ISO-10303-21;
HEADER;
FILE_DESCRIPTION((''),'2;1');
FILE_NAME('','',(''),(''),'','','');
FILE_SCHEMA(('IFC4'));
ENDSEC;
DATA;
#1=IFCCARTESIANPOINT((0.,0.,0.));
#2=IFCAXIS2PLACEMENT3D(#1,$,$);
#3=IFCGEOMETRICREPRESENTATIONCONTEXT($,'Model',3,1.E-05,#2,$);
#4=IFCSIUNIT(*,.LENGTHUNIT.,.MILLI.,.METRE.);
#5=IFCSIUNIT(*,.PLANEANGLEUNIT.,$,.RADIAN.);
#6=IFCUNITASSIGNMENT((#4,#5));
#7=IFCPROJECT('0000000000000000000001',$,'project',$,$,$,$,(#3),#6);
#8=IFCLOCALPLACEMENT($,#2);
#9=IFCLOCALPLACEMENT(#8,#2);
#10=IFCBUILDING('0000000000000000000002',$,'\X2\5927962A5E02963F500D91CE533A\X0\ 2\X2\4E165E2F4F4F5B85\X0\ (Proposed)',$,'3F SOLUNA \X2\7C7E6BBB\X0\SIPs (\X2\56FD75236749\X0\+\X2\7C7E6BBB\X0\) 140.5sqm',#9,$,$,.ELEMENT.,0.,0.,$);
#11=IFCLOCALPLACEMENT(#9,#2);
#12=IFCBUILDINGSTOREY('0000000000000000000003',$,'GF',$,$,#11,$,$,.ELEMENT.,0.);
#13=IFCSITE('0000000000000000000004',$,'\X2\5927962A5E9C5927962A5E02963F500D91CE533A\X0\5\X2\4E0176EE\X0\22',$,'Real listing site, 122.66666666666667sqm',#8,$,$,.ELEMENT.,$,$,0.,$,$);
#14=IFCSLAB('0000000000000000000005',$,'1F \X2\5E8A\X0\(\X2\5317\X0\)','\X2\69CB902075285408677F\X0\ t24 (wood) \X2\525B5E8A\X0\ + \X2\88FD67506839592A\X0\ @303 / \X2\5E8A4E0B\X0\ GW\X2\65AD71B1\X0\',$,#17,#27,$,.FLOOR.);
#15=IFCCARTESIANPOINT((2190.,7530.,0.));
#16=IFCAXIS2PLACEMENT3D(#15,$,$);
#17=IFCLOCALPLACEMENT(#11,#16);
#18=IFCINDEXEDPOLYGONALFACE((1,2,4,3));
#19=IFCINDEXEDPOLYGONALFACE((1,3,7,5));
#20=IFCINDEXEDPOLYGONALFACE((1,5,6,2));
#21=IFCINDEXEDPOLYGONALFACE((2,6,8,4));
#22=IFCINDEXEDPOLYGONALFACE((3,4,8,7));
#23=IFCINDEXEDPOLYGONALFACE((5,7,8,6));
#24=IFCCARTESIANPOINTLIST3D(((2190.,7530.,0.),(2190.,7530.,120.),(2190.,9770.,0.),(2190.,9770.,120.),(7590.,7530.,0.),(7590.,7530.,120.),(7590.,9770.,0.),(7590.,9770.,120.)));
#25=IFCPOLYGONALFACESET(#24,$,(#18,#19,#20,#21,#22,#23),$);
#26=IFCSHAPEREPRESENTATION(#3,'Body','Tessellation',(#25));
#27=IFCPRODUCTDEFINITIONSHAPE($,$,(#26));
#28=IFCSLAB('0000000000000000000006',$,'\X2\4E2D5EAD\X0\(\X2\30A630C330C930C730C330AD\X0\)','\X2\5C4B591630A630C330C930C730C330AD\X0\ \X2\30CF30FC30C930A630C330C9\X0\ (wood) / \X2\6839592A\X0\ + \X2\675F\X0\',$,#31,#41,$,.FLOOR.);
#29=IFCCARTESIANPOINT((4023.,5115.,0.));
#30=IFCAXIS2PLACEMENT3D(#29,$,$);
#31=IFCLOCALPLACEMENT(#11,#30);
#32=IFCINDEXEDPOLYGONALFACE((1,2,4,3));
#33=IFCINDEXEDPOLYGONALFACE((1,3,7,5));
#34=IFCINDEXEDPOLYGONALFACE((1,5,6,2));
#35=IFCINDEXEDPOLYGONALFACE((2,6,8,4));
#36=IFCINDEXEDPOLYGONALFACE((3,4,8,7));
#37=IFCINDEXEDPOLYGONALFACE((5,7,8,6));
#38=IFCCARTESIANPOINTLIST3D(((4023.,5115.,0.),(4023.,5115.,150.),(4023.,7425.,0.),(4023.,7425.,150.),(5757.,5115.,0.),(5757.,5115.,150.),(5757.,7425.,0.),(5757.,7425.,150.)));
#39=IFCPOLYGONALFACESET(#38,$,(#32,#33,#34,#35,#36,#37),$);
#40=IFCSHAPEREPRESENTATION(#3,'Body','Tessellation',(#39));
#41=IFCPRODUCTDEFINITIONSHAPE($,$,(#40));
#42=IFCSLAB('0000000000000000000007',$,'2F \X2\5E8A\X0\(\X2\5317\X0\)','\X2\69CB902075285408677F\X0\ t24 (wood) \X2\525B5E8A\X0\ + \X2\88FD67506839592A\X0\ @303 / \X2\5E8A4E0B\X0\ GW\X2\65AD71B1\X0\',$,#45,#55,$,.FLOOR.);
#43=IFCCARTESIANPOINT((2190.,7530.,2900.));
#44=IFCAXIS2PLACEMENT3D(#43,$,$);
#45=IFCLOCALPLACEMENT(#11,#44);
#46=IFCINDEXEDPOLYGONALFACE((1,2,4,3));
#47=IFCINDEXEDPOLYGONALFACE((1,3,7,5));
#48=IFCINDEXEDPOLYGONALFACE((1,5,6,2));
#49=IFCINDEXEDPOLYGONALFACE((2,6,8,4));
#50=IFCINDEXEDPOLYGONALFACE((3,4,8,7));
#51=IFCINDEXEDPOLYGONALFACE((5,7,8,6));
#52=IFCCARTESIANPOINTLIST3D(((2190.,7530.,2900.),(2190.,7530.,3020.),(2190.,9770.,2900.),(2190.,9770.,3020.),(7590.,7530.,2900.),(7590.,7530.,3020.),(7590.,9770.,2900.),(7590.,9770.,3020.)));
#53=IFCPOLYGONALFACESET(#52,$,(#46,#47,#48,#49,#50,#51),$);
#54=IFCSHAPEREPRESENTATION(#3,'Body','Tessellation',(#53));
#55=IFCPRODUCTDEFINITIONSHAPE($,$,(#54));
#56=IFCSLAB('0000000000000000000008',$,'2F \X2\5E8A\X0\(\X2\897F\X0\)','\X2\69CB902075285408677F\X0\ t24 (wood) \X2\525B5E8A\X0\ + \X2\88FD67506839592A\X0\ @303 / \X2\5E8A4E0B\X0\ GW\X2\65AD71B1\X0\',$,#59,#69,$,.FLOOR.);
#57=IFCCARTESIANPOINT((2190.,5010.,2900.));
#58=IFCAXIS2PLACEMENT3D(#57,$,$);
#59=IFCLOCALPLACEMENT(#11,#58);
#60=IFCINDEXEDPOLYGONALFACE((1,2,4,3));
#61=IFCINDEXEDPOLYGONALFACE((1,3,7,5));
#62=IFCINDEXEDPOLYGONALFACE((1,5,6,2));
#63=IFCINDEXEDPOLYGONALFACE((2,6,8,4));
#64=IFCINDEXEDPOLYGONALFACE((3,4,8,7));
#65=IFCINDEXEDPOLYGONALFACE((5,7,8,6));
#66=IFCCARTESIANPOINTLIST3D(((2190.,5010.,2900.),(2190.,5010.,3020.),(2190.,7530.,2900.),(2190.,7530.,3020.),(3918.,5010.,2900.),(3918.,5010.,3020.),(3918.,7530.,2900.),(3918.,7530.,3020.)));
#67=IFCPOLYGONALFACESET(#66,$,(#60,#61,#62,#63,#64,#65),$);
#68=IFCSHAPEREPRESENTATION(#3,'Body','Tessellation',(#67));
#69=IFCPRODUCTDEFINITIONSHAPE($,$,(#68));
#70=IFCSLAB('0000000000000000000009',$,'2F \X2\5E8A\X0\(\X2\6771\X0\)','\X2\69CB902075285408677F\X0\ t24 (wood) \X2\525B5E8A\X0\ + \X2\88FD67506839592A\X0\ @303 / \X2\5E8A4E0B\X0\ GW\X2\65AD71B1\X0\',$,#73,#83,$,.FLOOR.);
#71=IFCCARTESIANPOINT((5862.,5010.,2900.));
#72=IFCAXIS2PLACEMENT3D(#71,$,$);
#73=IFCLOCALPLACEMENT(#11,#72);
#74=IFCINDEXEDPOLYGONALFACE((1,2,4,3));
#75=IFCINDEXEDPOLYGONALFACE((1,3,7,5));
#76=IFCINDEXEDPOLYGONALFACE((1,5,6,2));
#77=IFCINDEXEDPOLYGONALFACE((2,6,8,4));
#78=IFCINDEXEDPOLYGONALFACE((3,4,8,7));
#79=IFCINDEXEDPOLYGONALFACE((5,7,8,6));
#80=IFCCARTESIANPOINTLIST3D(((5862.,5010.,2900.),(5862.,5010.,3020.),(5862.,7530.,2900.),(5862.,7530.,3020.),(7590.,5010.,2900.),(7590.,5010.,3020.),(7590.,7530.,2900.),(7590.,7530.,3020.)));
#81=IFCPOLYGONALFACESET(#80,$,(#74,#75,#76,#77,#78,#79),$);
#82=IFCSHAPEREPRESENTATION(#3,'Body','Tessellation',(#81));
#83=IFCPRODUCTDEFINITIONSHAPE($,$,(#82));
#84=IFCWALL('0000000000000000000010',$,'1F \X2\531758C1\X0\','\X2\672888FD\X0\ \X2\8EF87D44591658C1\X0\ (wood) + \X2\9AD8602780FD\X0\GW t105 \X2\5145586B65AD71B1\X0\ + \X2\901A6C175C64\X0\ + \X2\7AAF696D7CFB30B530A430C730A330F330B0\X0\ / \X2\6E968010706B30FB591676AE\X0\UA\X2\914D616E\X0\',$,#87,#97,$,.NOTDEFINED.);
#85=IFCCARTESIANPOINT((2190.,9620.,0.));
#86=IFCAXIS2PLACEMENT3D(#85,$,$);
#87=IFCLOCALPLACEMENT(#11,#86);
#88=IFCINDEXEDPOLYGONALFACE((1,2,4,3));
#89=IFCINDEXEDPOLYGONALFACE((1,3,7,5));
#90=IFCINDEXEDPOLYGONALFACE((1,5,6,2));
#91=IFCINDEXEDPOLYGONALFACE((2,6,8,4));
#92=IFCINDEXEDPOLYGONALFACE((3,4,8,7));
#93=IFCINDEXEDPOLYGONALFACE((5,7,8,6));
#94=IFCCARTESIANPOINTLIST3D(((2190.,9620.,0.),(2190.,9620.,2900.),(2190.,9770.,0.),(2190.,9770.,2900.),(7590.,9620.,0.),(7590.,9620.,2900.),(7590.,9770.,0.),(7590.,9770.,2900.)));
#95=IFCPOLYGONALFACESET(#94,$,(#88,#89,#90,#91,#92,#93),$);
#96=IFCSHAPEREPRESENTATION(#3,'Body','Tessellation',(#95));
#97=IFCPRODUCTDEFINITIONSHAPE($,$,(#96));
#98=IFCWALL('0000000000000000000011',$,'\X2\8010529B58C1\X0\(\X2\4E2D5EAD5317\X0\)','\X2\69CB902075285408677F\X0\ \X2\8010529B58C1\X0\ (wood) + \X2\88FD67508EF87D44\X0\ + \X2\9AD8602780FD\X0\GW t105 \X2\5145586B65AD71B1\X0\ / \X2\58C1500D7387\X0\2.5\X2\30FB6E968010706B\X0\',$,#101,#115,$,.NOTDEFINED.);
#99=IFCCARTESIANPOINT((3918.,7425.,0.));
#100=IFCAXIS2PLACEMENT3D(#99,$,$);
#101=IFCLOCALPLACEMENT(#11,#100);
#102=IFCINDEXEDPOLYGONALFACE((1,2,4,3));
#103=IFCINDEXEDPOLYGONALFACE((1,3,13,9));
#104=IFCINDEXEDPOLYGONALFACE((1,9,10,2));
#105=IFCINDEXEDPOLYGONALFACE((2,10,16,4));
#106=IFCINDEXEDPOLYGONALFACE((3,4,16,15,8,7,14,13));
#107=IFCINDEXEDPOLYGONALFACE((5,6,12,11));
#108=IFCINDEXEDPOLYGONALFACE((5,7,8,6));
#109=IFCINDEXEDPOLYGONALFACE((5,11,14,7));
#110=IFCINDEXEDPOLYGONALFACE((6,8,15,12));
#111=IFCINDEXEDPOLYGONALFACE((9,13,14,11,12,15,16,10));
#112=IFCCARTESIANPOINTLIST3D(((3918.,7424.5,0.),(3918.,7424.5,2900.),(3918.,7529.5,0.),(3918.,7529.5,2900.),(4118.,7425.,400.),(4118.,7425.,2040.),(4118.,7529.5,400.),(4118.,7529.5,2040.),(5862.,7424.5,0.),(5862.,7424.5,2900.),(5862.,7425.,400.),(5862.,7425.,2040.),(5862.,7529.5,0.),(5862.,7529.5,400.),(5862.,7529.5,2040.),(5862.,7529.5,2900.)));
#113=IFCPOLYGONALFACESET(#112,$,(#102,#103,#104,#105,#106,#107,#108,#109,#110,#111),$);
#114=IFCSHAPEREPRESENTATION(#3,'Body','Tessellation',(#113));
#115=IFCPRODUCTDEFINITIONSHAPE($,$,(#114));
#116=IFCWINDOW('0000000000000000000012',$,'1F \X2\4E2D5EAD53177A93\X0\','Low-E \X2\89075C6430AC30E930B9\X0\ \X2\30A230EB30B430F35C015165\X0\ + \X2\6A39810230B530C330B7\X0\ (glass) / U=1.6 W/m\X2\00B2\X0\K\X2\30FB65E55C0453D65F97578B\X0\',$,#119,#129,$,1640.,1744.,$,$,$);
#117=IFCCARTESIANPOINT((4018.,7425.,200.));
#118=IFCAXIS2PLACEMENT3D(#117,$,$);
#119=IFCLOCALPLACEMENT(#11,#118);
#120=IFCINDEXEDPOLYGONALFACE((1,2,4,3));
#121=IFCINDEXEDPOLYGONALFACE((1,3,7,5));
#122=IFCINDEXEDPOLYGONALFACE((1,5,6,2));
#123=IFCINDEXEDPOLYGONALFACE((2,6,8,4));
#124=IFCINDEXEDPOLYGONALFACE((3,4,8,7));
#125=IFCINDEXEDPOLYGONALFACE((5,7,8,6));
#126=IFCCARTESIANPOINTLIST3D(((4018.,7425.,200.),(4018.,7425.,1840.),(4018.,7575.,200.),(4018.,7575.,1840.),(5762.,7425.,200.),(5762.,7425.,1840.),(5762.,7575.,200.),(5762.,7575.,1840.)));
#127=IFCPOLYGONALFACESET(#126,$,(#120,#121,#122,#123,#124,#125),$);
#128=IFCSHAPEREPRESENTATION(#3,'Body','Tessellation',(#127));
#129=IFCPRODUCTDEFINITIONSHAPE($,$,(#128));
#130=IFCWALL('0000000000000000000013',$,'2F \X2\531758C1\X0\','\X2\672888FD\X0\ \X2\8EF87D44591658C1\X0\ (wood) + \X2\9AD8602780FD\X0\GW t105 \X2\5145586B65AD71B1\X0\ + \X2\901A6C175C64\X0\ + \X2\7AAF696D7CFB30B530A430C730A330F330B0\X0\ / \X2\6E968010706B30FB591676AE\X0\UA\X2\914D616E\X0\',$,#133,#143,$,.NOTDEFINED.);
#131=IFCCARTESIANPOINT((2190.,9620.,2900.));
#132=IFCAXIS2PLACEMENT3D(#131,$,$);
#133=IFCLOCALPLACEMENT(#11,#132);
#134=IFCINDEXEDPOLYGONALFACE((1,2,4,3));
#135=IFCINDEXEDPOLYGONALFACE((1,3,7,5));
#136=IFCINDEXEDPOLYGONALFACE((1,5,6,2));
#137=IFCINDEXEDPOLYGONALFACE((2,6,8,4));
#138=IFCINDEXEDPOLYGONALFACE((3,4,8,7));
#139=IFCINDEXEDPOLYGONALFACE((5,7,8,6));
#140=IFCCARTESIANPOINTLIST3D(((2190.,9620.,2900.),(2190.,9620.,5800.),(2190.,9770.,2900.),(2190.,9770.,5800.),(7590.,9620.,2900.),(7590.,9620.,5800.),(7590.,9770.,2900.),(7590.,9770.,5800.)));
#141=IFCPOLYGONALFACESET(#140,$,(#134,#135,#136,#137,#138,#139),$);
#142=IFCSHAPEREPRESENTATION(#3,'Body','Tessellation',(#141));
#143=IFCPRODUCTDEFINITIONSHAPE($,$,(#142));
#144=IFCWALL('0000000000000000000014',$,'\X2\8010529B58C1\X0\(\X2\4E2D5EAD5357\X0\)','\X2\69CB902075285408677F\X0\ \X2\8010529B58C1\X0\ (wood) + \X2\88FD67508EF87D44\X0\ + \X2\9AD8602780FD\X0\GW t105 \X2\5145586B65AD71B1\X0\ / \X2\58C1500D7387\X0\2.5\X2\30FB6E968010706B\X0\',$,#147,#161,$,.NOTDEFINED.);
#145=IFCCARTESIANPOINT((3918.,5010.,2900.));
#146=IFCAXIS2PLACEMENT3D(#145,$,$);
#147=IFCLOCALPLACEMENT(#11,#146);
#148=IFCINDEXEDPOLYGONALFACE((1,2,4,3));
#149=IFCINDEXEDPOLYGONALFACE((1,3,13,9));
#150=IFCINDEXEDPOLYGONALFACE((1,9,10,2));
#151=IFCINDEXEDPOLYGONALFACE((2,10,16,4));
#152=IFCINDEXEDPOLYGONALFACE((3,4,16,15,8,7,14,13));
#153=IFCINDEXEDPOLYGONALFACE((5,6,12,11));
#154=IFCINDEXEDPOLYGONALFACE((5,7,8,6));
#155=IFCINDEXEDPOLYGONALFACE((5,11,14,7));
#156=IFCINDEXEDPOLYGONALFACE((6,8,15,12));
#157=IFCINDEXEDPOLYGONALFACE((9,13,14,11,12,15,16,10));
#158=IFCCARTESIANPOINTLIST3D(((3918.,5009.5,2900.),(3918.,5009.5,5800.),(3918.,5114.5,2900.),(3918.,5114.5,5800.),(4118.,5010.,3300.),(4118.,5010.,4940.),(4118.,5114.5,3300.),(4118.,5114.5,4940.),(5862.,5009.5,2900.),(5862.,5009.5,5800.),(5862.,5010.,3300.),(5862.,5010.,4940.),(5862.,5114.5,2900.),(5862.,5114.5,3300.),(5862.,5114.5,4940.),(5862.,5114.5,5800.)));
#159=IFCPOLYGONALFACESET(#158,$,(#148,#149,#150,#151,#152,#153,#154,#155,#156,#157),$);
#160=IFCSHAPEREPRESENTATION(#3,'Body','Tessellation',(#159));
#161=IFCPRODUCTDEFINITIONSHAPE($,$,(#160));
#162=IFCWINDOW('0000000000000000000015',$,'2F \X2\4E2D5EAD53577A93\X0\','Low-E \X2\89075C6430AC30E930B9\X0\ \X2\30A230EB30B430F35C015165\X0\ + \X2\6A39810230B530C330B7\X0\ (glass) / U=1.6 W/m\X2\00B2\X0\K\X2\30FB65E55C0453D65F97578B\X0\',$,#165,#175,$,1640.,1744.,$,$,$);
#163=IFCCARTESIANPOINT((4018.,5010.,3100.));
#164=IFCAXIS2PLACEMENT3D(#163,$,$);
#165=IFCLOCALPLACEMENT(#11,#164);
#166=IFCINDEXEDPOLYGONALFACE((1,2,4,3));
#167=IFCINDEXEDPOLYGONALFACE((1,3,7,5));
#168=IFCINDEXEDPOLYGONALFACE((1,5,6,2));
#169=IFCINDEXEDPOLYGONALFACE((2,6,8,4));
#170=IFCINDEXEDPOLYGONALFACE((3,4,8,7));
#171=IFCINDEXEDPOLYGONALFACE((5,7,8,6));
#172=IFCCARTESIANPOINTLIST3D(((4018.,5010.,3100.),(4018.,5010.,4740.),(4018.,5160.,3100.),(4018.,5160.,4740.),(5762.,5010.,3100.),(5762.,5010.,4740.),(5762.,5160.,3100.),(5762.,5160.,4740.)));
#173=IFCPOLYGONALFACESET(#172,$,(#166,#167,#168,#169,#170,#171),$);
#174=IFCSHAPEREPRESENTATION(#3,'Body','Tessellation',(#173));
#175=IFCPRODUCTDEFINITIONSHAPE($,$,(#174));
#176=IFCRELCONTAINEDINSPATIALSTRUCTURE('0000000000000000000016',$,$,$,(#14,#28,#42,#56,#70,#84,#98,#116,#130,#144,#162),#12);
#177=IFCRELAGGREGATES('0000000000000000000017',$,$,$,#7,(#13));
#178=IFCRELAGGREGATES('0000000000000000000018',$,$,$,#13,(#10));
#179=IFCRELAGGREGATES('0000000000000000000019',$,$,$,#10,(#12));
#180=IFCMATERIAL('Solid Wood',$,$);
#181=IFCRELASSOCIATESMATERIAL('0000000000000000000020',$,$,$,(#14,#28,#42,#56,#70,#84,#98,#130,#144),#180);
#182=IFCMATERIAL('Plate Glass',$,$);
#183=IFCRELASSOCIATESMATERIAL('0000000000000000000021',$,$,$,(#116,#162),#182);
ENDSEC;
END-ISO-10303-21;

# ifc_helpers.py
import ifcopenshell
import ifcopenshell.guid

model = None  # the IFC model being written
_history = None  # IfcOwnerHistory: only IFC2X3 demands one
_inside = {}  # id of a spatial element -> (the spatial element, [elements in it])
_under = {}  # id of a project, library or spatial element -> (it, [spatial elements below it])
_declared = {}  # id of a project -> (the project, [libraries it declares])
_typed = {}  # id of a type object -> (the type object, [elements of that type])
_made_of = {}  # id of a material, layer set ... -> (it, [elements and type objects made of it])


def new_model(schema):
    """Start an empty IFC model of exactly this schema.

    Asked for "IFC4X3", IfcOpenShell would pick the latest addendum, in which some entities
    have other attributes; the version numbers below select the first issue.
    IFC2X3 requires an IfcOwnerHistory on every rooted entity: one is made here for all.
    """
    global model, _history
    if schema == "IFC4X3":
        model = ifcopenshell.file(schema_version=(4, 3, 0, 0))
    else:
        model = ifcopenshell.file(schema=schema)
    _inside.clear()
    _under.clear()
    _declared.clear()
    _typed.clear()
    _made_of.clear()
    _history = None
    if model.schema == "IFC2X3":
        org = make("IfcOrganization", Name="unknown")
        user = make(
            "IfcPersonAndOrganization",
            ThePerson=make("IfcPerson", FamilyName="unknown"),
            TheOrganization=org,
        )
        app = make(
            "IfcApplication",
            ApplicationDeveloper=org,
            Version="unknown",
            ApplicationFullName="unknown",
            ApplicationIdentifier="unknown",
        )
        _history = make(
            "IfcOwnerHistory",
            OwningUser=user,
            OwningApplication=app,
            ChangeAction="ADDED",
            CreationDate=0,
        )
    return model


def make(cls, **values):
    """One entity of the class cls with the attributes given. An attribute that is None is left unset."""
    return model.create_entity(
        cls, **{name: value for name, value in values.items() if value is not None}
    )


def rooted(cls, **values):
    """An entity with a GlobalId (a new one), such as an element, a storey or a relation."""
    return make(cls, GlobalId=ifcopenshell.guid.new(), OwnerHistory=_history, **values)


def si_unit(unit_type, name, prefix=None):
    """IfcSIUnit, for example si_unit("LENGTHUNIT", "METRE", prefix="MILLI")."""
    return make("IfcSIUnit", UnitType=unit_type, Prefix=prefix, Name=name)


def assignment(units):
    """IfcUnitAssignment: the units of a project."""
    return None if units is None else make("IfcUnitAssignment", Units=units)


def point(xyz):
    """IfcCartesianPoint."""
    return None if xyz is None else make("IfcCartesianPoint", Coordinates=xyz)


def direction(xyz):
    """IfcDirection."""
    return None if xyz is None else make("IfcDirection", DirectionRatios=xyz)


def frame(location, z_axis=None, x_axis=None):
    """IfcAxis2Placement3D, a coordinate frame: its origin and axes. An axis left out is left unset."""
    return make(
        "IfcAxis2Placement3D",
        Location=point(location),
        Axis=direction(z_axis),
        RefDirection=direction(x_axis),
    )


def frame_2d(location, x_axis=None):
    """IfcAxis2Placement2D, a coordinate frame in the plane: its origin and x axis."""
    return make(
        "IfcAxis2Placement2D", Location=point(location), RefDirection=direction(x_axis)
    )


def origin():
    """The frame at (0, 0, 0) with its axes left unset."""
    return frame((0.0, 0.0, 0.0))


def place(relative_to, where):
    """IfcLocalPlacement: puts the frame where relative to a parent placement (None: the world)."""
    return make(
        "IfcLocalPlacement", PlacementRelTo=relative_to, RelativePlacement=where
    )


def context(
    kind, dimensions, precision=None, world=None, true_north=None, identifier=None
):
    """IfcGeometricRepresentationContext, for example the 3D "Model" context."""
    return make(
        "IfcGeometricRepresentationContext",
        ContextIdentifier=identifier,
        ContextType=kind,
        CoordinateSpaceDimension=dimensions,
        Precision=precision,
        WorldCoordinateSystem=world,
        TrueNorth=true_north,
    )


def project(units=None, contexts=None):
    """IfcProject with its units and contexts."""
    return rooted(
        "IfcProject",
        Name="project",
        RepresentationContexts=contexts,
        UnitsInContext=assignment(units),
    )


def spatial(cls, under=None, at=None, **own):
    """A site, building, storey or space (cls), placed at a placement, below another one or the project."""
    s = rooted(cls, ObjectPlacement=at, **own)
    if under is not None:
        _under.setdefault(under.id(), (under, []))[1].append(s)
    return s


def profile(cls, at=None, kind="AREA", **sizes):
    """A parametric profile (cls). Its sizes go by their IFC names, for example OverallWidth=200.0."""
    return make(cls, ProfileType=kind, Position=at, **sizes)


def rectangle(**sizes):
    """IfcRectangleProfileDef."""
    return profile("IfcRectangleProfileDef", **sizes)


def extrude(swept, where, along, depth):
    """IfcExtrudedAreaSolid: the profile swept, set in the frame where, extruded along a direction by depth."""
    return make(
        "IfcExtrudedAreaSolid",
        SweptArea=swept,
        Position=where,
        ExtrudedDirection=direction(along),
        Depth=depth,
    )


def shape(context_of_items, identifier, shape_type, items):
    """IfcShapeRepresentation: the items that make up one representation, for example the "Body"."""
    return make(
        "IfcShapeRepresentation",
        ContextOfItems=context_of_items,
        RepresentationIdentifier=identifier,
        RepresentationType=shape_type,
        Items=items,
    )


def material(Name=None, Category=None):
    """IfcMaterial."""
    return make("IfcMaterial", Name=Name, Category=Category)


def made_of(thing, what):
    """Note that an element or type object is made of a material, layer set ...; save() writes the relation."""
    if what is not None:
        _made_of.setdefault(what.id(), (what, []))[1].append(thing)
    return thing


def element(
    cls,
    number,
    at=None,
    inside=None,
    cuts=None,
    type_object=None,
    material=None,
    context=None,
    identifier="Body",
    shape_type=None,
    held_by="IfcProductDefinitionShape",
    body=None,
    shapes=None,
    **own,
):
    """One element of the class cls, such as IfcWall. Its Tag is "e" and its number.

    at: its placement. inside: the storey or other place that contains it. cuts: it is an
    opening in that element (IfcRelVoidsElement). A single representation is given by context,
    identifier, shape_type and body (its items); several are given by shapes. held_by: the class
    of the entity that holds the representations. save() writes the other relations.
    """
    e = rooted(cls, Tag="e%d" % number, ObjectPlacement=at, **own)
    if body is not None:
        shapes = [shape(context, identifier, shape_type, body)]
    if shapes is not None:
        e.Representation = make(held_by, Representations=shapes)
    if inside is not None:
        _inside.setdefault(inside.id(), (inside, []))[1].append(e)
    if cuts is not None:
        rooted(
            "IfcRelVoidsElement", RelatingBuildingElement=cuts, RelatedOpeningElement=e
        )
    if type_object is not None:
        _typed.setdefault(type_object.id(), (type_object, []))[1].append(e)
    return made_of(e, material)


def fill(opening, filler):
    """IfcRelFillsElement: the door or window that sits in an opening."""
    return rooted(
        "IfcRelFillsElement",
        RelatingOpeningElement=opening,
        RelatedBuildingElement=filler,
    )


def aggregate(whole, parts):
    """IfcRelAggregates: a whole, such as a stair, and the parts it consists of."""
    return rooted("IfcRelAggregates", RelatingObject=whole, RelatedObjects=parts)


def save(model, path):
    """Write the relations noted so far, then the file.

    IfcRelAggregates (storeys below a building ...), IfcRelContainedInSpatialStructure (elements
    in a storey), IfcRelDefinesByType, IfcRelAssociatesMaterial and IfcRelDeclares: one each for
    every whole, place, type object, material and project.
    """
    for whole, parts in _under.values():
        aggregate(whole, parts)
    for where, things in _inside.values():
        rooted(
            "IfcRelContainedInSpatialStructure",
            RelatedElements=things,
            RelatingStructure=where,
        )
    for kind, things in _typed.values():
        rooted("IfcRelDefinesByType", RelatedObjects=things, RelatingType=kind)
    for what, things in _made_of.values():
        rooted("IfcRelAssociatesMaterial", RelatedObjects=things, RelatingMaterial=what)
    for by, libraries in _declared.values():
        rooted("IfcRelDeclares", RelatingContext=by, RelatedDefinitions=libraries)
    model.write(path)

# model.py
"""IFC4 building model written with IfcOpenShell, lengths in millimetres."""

from ifc_helpers import new_model, si_unit, frame, frame_2d, origin, place, context, project, spatial, rectangle, extrude, material, element, fill, save


model = new_model("IFC4")

# Units and contexts
model_context = context("Model", 3, precision=1e-05, world=origin())
ifc_project = project(units=[si_unit("LENGTHUNIT", "METRE", prefix="MILLI"), si_unit("PLANEANGLEUNIT", "RADIAN")], contexts=[model_context])

# Site, building, storey
site_placement = place(None, origin())
site = spatial("IfcSite", under=ifc_project, at=site_placement, Name="大阪府大阪市阿倍野区5丁目22", ObjectType="Real listing site, 122.66666666666667sqm", CompositionType="ELEMENT", RefElevation=0.0)
building_placement = place(site_placement, origin())
building = spatial("IfcBuilding", under=site, at=building_placement, Name="大阪市阿倍野区 2世帯住宅 (Proposed)", ObjectType="3F SOLUNA 籾殻SIPs (国産杉+籾殻) 140.5sqm", CompositionType="ELEMENT", ElevationOfRefHeight=0.0, ElevationOfTerrain=0.0)
storey_placement = place(building_placement, origin())
storey = spatial("IfcBuildingStorey", under=building, at=storey_placement, Name="GF", CompositionType="ELEMENT", Elevation=0.0)

# Slabs
ifc_material_1 = material(Name="Solid Wood")
slab_1_placement = place(storey_placement, frame((2190.0, 7530.0, 0.0)))
element("IfcSlab", 1, at=slab_1_placement, inside=storey, material=ifc_material_1, Name="1F 床(北)", Description="構造用合板 t24 (wood) 剛床 + 製材根太 @303 / 床下 GW断熱", PredefinedType="FLOOR", context=model_context, shape_type="SweptSolid", body=[
    extrude(rectangle(XDim=5400.0, YDim=2240.0, at=frame_2d((2700.0, 1120.0))), frame((2190.0, 7530.0, 0.0)), (0.0, 0.0, 1.0), 120.0),
])
slab_2_placement = place(storey_placement, frame((4023.0, 5115.0, 0.0)))
element("IfcSlab", 2, at=slab_2_placement, inside=storey, material=ifc_material_1, Name="中庭(ウッドデッキ)", Description="屋外ウッドデッキ ハードウッド (wood) / 根太 + 束", PredefinedType="FLOOR", context=model_context, shape_type="SweptSolid", body=[
    extrude(rectangle(XDim=1734.0, YDim=2310.0, at=frame_2d((867.0, 1155.0))), frame((4023.0, 5115.0, 0.0)), (0.0, 0.0, 1.0), 150.0),
])
slab_3_placement = place(storey_placement, frame((2190.0, 7530.0, 2900.0)))
element("IfcSlab", 3, at=slab_3_placement, inside=storey, material=ifc_material_1, Name="2F 床(北)", Description="構造用合板 t24 (wood) 剛床 + 製材根太 @303 / 床下 GW断熱", PredefinedType="FLOOR", context=model_context, shape_type="SweptSolid", body=[
    extrude(rectangle(XDim=5400.0, YDim=2240.0, at=frame_2d((2700.0, 1120.0))), frame((2190.0, 7530.0, 2900.0)), (0.0, 0.0, 1.0), 120.0),
])
slab_4_placement = place(storey_placement, frame((2190.0, 5010.0, 2900.0)))
element("IfcSlab", 4, at=slab_4_placement, inside=storey, material=ifc_material_1, Name="2F 床(西)", Description="構造用合板 t24 (wood) 剛床 + 製材根太 @303 / 床下 GW断熱", PredefinedType="FLOOR", context=model_context, shape_type="SweptSolid", body=[
    extrude(rectangle(XDim=1728.0, YDim=2520.0, at=frame_2d((864.0, 1260.0))), frame((2190.0, 5010.0, 2900.0)), (0.0, 0.0, 1.0), 120.0),
])
slab_5_placement = place(storey_placement, frame((5862.0, 5010.0, 2900.0)))
element("IfcSlab", 5, at=slab_5_placement, inside=storey, material=ifc_material_1, Name="2F 床(東)", Description="構造用合板 t24 (wood) 剛床 + 製材根太 @303 / 床下 GW断熱", PredefinedType="FLOOR", context=model_context, shape_type="SweptSolid", body=[
    extrude(rectangle(XDim=1728.0, YDim=2520.0, at=frame_2d((864.0, 1260.0))), frame((5862.0, 5010.0, 2900.0)), (0.0, 0.0, 1.0), 120.0),
])

# Wall
wall_1_placement = place(storey_placement, frame((2190.0, 9620.0, 0.0)))
element("IfcWall", 6, at=wall_1_placement, inside=storey, material=ifc_material_1, Name="1F 北壁", Description="木製 軸組外壁 (wood) + 高性能GW t105 充填断熱 + 通気層 + 窯業系サイディング / 準耐火・外皮UA配慮", PredefinedType="NOTDEFINED", context=model_context, shape_type="SweptSolid", body=[
    extrude(rectangle(XDim=5400.0, YDim=150.0, at=frame_2d((2700.0, 75.0))), frame((2190.0, 9620.0, 0.0)), (0.0, 0.0, 1.0), 2900.0),
])

# Wall, opening, window
wall_2_placement = place(storey_placement, frame((3918.0, 7425.0, 0.0)))
wall_2 = element("IfcWall", 7, at=wall_2_placement, inside=storey, material=ifc_material_1, Name="耐力壁(中庭北)", Description="構造用合板 耐力壁 (wood) + 製材軸組 + 高性能GW t105 充填断熱 / 壁倍率2.5・準耐火", PredefinedType="NOTDEFINED", context=model_context, shape_type="SweptSolid", body=[
    extrude(rectangle(XDim=1944.0, YDim=105.0, at=frame_2d((972.0, 52.0))), frame((3918.0, 7425.0, 0.0)), (0.0, 0.0, 1.0), 2900.0),
])
opening_1_placement = place(storey_placement, frame((4018.0, 7425.0, 200.0)))
opening_1 = element("IfcOpeningElement", 8, at=opening_1_placement, cuts=wall_2, PredefinedType="NOTDEFINED", context=model_context, shape_type="SweptSolid", body=[
    extrude(rectangle(XDim=1744.0, YDim=150.0, at=frame_2d((872.0, 75.0))), frame((4018.0, 7425.0, 200.0)), (0.0, 0.0, 1.0), 1640.0),
])
ifc_material_2 = material(Name="Plate Glass")
window_1_placement = place(storey_placement, frame((4018.0, 7425.0, 200.0)))
window_1 = element("IfcWindow", 9, at=window_1_placement, inside=storey, material=ifc_material_2, Name="1F 中庭北窓", Description="Low-E 複層ガラス アルゴン封入 + 樹脂サッシ (glass) / U=1.6 W/m²K・日射取得型", OverallHeight=1640.0, OverallWidth=1744.0, context=model_context, shape_type="SweptSolid", body=[
    extrude(rectangle(XDim=1744.0, YDim=150.0, at=frame_2d((872.0, 75.0))), frame((4018.0, 7425.0, 200.0)), (0.0, 0.0, 1.0), 1640.0),
])
fill(opening_1, window_1)

# Wall
wall_3_placement = place(storey_placement, frame((2190.0, 9620.0, 2900.0)))
element("IfcWall", 10, at=wall_3_placement, inside=storey, material=ifc_material_1, Name="2F 北壁", Description="木製 軸組外壁 (wood) + 高性能GW t105 充填断熱 + 通気層 + 窯業系サイディング / 準耐火・外皮UA配慮", PredefinedType="NOTDEFINED", context=model_context, shape_type="SweptSolid", body=[
    extrude(rectangle(XDim=5400.0, YDim=150.0, at=frame_2d((2700.0, 75.0))), frame((2190.0, 9620.0, 2900.0)), (0.0, 0.0, 1.0), 2900.0),
])

# Wall, opening, window
wall_4_placement = place(storey_placement, frame((3918.0, 5010.0, 2900.0)))
wall_4 = element("IfcWall", 11, at=wall_4_placement, inside=storey, material=ifc_material_1, Name="耐力壁(中庭南)", Description="構造用合板 耐力壁 (wood) + 製材軸組 + 高性能GW t105 充填断熱 / 壁倍率2.5・準耐火", PredefinedType="NOTDEFINED", context=model_context, shape_type="SweptSolid", body=[
    extrude(rectangle(XDim=1944.0, YDim=105.0, at=frame_2d((972.0, 52.0))), frame((3918.0, 5010.0, 2900.0)), (0.0, 0.0, 1.0), 2900.0),
])
opening_2_placement = place(storey_placement, frame((4018.0, 5010.0, 3100.0)))
opening_2 = element("IfcOpeningElement", 12, at=opening_2_placement, cuts=wall_4, PredefinedType="NOTDEFINED", context=model_context, shape_type="SweptSolid", body=[
    extrude(rectangle(XDim=1744.0, YDim=150.0, at=frame_2d((872.0, 75.0))), frame((4018.0, 5010.0, 3100.0)), (0.0, 0.0, 1.0), 1640.0),
])
window_2_placement = place(storey_placement, frame((4018.0, 5010.0, 3100.0)))
window_2 = element("IfcWindow", 13, at=window_2_placement, inside=storey, material=ifc_material_2, Name="2F 中庭南窓", Description="Low-E 複層ガラス アルゴン封入 + 樹脂サッシ (glass) / U=1.6 W/m²K・日射取得型", OverallHeight=1640.0, OverallWidth=1744.0, context=model_context, shape_type="SweptSolid", body=[
    extrude(rectangle(XDim=1744.0, YDim=150.0, at=frame_2d((872.0, 75.0))), frame((4018.0, 5010.0, 3100.0)), (0.0, 0.0, 1.0), 1640.0),
])
fill(opening_2, window_2)

save(model, "model.ifc")
